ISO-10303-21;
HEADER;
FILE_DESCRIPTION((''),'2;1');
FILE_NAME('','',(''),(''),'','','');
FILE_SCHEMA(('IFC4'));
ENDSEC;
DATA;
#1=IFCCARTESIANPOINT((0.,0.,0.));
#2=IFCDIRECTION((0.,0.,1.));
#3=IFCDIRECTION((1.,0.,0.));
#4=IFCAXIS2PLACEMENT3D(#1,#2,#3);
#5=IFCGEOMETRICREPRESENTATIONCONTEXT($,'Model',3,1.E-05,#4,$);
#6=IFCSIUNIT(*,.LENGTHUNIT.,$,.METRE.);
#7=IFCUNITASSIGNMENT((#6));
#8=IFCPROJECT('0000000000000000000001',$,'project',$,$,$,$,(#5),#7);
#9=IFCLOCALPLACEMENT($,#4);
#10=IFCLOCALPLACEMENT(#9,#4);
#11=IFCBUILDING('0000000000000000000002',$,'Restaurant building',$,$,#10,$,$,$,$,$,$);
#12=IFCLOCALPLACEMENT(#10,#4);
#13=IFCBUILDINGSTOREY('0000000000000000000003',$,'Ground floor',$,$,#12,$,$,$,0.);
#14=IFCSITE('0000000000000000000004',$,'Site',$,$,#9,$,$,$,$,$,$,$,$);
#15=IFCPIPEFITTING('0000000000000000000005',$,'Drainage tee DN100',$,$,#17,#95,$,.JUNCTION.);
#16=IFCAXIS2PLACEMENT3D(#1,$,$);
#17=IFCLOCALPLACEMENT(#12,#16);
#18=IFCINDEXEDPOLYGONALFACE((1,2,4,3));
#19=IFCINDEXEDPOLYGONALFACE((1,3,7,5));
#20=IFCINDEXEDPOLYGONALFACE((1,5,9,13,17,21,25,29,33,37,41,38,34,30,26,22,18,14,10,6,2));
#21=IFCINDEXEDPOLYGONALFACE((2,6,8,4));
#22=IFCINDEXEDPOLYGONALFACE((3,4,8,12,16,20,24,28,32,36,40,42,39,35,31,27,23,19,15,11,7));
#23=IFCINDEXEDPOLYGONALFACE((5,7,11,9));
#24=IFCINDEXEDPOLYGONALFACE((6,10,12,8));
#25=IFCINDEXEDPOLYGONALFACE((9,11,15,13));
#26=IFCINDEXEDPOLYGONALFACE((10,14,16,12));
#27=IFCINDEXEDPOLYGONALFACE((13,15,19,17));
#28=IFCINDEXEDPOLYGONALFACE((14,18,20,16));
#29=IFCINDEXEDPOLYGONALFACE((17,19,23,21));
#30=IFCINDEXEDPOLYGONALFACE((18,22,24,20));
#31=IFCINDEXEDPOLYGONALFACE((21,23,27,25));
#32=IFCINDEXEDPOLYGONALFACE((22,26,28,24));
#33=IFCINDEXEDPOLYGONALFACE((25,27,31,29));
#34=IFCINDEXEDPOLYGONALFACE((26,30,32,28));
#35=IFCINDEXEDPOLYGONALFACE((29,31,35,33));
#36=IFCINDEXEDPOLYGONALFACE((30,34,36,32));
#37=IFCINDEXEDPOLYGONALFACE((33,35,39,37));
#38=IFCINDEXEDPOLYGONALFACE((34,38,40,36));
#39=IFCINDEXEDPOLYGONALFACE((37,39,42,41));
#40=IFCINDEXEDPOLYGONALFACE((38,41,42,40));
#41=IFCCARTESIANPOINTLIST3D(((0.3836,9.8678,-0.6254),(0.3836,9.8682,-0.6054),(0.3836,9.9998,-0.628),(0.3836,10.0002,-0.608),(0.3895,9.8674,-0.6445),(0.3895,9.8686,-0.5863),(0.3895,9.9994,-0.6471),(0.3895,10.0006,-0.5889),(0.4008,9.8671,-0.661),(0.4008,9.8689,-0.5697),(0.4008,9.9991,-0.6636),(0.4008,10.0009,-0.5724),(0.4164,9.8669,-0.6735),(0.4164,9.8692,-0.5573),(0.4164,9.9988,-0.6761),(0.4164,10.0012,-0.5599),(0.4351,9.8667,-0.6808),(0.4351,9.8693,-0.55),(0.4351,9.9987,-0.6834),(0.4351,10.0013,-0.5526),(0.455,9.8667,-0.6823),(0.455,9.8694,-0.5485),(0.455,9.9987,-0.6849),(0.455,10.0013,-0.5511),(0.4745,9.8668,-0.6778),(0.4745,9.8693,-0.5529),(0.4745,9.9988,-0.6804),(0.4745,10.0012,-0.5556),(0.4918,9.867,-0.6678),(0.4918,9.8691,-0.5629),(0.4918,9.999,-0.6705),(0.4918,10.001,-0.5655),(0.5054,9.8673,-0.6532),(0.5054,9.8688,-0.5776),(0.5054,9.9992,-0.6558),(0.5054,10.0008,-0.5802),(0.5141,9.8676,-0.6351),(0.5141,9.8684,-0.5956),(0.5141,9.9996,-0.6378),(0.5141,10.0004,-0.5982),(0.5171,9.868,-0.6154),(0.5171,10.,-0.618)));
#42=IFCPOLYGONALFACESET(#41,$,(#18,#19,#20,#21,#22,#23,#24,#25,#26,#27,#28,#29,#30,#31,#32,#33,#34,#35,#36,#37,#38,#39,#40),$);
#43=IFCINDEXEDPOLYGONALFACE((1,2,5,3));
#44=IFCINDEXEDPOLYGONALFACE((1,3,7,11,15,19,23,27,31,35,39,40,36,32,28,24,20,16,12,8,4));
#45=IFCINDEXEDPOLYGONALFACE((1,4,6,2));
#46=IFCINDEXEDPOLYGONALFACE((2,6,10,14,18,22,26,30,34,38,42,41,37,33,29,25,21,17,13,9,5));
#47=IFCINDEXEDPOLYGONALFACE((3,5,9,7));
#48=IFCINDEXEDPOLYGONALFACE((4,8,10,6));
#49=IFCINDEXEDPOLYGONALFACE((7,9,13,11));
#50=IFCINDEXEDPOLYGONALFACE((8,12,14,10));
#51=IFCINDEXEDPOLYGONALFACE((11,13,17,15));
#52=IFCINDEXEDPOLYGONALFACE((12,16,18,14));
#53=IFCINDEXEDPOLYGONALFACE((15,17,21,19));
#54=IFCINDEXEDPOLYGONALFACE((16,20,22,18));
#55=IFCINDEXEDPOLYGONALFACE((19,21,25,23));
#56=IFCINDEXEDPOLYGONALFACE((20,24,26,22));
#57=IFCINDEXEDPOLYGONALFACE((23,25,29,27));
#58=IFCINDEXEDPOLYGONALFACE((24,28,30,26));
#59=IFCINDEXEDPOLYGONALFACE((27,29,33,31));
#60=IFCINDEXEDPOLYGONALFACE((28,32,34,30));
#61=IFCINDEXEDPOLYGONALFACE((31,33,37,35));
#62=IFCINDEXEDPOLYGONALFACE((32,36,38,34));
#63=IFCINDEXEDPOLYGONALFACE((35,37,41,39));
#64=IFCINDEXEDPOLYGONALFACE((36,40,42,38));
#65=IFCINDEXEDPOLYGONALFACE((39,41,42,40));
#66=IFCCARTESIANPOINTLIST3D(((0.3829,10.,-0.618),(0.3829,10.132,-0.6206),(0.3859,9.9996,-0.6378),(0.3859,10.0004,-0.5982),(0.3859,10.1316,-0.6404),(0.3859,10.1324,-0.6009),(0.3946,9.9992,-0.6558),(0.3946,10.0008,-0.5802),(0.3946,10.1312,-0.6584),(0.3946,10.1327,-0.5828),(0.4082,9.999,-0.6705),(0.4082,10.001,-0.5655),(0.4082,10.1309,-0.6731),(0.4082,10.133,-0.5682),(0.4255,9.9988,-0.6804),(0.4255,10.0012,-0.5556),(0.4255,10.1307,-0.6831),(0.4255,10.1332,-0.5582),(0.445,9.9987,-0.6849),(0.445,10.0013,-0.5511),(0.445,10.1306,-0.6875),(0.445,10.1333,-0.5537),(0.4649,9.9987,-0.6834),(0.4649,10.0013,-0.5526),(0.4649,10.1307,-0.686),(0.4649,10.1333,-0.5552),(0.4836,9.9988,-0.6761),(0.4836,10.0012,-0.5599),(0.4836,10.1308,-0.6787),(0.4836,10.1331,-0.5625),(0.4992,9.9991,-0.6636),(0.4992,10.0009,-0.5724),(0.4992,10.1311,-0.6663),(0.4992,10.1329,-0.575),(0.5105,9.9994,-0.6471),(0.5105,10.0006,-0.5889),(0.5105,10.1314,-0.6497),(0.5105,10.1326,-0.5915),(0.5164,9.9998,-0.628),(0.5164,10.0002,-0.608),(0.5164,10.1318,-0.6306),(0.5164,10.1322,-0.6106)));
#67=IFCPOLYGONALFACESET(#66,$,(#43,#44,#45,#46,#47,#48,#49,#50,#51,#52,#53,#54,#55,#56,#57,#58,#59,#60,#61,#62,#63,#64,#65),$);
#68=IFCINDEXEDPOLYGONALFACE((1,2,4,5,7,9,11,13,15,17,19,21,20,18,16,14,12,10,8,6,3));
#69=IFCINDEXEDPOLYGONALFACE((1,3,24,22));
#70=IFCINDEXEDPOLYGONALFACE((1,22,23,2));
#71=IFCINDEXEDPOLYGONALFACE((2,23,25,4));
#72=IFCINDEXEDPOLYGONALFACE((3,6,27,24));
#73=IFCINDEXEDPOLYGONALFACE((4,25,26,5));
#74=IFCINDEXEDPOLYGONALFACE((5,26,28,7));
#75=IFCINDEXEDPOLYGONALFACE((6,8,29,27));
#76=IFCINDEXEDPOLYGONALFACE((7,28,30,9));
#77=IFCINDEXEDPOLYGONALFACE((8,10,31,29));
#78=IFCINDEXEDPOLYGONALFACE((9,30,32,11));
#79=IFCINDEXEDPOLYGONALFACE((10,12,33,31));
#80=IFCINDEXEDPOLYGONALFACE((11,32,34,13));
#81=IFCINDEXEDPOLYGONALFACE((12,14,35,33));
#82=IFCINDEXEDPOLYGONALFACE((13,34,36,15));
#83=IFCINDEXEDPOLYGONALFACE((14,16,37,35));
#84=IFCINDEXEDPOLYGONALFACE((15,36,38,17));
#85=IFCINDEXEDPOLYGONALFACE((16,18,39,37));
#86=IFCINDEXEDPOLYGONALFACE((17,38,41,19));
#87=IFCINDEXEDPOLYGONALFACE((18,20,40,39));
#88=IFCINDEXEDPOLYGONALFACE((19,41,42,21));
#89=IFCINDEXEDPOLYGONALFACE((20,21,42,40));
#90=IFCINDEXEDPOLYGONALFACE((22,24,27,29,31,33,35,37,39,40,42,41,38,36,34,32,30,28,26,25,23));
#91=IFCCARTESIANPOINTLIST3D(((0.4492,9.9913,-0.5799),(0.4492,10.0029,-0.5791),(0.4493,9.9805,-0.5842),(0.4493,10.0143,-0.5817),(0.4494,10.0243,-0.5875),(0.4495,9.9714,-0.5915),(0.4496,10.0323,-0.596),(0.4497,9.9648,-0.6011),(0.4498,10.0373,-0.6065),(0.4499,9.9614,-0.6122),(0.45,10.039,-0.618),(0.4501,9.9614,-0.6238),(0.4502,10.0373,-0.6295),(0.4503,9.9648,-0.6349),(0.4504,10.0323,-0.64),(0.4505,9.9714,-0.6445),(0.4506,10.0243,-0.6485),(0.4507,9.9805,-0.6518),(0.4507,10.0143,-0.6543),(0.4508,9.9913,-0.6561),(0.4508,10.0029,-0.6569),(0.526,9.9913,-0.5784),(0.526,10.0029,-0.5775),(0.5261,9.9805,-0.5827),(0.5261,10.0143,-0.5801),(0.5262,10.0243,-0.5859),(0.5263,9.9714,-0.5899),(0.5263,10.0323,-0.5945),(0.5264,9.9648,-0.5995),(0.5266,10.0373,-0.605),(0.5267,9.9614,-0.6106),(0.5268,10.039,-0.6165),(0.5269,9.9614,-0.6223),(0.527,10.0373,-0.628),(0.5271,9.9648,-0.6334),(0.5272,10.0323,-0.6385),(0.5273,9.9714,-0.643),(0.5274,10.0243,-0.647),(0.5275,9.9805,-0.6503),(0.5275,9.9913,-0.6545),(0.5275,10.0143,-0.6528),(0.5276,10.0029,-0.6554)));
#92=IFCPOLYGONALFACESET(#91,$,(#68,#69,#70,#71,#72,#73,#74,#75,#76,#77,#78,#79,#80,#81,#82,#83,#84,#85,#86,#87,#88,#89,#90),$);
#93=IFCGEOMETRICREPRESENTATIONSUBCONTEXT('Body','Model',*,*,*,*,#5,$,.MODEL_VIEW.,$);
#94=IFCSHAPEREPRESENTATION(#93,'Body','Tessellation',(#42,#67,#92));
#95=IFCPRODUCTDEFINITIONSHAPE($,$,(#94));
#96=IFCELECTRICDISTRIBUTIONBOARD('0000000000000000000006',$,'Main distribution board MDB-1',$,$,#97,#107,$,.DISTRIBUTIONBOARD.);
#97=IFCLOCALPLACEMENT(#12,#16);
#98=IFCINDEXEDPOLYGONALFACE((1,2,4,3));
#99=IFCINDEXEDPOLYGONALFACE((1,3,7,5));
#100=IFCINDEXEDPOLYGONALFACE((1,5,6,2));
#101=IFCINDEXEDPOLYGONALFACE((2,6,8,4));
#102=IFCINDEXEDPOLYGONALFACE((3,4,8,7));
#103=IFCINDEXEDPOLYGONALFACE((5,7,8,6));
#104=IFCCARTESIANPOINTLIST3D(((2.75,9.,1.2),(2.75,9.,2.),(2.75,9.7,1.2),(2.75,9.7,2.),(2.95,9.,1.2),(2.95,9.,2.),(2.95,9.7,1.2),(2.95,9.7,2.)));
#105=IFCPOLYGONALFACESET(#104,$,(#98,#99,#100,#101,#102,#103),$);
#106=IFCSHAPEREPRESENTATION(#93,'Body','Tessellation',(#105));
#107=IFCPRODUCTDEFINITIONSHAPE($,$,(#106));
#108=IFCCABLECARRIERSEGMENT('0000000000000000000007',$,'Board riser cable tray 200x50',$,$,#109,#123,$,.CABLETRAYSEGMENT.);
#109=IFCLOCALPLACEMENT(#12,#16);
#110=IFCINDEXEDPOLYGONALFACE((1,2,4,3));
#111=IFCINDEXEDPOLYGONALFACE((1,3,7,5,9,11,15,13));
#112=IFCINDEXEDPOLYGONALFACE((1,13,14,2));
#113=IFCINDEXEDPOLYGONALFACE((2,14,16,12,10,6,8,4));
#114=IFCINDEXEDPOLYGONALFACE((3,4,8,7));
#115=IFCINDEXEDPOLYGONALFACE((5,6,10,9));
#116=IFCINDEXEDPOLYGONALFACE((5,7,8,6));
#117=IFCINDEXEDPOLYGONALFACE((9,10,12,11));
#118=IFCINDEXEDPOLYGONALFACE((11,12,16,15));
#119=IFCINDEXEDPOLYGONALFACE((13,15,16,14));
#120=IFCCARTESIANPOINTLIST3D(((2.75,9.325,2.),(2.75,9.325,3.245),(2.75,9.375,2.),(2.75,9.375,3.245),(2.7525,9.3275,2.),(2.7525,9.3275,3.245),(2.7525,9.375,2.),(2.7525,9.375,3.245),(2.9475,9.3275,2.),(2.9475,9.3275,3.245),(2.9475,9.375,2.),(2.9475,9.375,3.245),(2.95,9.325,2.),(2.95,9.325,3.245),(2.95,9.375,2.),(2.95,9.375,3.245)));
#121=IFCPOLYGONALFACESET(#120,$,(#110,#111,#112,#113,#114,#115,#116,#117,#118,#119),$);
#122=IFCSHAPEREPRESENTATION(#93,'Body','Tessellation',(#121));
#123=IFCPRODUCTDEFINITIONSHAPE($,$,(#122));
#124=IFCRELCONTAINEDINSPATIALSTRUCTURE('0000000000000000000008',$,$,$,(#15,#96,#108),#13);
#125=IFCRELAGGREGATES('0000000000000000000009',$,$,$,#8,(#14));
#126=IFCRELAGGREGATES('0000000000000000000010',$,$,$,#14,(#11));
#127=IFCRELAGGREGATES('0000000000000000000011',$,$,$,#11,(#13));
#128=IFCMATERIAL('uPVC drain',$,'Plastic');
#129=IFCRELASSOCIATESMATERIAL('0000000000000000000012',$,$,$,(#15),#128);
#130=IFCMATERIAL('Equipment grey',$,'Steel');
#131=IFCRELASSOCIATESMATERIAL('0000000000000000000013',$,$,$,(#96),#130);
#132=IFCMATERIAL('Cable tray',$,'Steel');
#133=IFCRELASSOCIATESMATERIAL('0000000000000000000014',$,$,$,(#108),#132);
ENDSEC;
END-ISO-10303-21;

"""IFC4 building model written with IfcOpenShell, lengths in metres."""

from ifc_helpers import new_model, si_unit, frame, origin, origin_with_axes, origin_2d, place, context, subcontext, project, spatial, polyline, rectangle, circle, outline, extrude, material, element, save


model = new_model("IFC4")

# Units and contexts
model_context = context("Model", 3, precision=1e-05, world=origin_with_axes())
body_context = subcontext(model_context, "Body", "Model", "MODEL_VIEW")
ifc_project = project(units=[si_unit("LENGTHUNIT", "METRE")], contexts=[model_context])

# Site, building, storey
site_placement = place(None, origin_with_axes())
site = spatial("IfcSite", under=ifc_project, at=site_placement, Name="Site")
building_placement = place(site_placement, origin_with_axes())
building = spatial("IfcBuilding", under=site, at=building_placement, Name="Restaurant building")
storey_placement = place(building_placement, origin_with_axes())
storey = spatial("IfcBuildingStorey", under=building, at=storey_placement, Name="Ground floor", Elevation=0.0)

# Shared definitions
ifc_material_1 = material(Name="uPVC drain", Category="Plastic")

# Pipe fitting
pipe_fitting_1_placement = place(storey_placement, frame((0.45, 10.0, -0.618)))
element("IfcPipeFitting", 1, at=pipe_fitting_1_placement, inside=storey, material=ifc_material_1, Name="Drainage tee DN100", PredefinedType="JUNCTION", context=body_context, shape_type="SweptSolid", body=[
    extrude(circle(Radius=0.0671, at=origin_2d()), frame((0.0, 0.0, 0.0), z_axis=(0.0, -0.9998, 0.019996), x_axis=(1.0, 0.0, 0.0)), (0.0, 0.0, 1.0), 0.132),
    extrude(circle(Radius=0.0671, at=origin_2d()), frame((0.0, 0.0, 0.0), z_axis=(0.0, 0.9998, -0.019996), x_axis=(-1.0, 0.0, 0.0)), (0.0, 0.0, 1.0), 0.132),
    extrude(circle(Radius=0.039, at=origin_2d()), frame((0.0, 0.0, 0.0), z_axis=(0.9998, 0.0, 0.019996), x_axis=(0.0, 1.0, 0.0)), (0.0, 0.0, 1.0), 0.0768),
])

# Electric distribution board
ifc_material_2 = material(Name="Equipment grey", Category="Steel")
electric_distribution_board_placement = place(storey_placement, frame((2.85, 9.35, 0.0)))
element("IfcElectricDistributionBoard", 2, at=electric_distribution_board_placement, inside=storey, material=ifc_material_2, Name="Main distribution board MDB-1", PredefinedType="DISTRIBUTIONBOARD", context=body_context, shape_type="SweptSolid", body=[
    extrude(rectangle(XDim=0.2, YDim=0.7, at=origin_2d()), frame((0.0, 0.0, 1.2)), (0.0, 0.0, 1.0), 0.8),
])

# Cable carrier segment
ifc_material_3 = material(Name="Cable tray", Category="Steel")
cable_carrier_segment_placement = place(storey_placement, frame((2.85, 9.35, 2.0)))
element("IfcCableCarrierSegment", 3, at=cable_carrier_segment_placement, inside=storey, material=ifc_material_3, Name="Board riser cable tray 200x50", PredefinedType="CABLETRAYSEGMENT", context=body_context, shape_type="SweptSolid", body=[
    extrude(outline(polyline([(-0.1, -0.025), (0.1, -0.025), (0.1, 0.025), (0.0975, 0.025), (0.0975, -0.0225), (-0.0975, -0.0225), (-0.0975, 0.025), (-0.1, 0.025), (-0.1, -0.025)])), origin(), (0.0, 0.0, 1.0), 1.245),
])

save(model, "model.ifc")
